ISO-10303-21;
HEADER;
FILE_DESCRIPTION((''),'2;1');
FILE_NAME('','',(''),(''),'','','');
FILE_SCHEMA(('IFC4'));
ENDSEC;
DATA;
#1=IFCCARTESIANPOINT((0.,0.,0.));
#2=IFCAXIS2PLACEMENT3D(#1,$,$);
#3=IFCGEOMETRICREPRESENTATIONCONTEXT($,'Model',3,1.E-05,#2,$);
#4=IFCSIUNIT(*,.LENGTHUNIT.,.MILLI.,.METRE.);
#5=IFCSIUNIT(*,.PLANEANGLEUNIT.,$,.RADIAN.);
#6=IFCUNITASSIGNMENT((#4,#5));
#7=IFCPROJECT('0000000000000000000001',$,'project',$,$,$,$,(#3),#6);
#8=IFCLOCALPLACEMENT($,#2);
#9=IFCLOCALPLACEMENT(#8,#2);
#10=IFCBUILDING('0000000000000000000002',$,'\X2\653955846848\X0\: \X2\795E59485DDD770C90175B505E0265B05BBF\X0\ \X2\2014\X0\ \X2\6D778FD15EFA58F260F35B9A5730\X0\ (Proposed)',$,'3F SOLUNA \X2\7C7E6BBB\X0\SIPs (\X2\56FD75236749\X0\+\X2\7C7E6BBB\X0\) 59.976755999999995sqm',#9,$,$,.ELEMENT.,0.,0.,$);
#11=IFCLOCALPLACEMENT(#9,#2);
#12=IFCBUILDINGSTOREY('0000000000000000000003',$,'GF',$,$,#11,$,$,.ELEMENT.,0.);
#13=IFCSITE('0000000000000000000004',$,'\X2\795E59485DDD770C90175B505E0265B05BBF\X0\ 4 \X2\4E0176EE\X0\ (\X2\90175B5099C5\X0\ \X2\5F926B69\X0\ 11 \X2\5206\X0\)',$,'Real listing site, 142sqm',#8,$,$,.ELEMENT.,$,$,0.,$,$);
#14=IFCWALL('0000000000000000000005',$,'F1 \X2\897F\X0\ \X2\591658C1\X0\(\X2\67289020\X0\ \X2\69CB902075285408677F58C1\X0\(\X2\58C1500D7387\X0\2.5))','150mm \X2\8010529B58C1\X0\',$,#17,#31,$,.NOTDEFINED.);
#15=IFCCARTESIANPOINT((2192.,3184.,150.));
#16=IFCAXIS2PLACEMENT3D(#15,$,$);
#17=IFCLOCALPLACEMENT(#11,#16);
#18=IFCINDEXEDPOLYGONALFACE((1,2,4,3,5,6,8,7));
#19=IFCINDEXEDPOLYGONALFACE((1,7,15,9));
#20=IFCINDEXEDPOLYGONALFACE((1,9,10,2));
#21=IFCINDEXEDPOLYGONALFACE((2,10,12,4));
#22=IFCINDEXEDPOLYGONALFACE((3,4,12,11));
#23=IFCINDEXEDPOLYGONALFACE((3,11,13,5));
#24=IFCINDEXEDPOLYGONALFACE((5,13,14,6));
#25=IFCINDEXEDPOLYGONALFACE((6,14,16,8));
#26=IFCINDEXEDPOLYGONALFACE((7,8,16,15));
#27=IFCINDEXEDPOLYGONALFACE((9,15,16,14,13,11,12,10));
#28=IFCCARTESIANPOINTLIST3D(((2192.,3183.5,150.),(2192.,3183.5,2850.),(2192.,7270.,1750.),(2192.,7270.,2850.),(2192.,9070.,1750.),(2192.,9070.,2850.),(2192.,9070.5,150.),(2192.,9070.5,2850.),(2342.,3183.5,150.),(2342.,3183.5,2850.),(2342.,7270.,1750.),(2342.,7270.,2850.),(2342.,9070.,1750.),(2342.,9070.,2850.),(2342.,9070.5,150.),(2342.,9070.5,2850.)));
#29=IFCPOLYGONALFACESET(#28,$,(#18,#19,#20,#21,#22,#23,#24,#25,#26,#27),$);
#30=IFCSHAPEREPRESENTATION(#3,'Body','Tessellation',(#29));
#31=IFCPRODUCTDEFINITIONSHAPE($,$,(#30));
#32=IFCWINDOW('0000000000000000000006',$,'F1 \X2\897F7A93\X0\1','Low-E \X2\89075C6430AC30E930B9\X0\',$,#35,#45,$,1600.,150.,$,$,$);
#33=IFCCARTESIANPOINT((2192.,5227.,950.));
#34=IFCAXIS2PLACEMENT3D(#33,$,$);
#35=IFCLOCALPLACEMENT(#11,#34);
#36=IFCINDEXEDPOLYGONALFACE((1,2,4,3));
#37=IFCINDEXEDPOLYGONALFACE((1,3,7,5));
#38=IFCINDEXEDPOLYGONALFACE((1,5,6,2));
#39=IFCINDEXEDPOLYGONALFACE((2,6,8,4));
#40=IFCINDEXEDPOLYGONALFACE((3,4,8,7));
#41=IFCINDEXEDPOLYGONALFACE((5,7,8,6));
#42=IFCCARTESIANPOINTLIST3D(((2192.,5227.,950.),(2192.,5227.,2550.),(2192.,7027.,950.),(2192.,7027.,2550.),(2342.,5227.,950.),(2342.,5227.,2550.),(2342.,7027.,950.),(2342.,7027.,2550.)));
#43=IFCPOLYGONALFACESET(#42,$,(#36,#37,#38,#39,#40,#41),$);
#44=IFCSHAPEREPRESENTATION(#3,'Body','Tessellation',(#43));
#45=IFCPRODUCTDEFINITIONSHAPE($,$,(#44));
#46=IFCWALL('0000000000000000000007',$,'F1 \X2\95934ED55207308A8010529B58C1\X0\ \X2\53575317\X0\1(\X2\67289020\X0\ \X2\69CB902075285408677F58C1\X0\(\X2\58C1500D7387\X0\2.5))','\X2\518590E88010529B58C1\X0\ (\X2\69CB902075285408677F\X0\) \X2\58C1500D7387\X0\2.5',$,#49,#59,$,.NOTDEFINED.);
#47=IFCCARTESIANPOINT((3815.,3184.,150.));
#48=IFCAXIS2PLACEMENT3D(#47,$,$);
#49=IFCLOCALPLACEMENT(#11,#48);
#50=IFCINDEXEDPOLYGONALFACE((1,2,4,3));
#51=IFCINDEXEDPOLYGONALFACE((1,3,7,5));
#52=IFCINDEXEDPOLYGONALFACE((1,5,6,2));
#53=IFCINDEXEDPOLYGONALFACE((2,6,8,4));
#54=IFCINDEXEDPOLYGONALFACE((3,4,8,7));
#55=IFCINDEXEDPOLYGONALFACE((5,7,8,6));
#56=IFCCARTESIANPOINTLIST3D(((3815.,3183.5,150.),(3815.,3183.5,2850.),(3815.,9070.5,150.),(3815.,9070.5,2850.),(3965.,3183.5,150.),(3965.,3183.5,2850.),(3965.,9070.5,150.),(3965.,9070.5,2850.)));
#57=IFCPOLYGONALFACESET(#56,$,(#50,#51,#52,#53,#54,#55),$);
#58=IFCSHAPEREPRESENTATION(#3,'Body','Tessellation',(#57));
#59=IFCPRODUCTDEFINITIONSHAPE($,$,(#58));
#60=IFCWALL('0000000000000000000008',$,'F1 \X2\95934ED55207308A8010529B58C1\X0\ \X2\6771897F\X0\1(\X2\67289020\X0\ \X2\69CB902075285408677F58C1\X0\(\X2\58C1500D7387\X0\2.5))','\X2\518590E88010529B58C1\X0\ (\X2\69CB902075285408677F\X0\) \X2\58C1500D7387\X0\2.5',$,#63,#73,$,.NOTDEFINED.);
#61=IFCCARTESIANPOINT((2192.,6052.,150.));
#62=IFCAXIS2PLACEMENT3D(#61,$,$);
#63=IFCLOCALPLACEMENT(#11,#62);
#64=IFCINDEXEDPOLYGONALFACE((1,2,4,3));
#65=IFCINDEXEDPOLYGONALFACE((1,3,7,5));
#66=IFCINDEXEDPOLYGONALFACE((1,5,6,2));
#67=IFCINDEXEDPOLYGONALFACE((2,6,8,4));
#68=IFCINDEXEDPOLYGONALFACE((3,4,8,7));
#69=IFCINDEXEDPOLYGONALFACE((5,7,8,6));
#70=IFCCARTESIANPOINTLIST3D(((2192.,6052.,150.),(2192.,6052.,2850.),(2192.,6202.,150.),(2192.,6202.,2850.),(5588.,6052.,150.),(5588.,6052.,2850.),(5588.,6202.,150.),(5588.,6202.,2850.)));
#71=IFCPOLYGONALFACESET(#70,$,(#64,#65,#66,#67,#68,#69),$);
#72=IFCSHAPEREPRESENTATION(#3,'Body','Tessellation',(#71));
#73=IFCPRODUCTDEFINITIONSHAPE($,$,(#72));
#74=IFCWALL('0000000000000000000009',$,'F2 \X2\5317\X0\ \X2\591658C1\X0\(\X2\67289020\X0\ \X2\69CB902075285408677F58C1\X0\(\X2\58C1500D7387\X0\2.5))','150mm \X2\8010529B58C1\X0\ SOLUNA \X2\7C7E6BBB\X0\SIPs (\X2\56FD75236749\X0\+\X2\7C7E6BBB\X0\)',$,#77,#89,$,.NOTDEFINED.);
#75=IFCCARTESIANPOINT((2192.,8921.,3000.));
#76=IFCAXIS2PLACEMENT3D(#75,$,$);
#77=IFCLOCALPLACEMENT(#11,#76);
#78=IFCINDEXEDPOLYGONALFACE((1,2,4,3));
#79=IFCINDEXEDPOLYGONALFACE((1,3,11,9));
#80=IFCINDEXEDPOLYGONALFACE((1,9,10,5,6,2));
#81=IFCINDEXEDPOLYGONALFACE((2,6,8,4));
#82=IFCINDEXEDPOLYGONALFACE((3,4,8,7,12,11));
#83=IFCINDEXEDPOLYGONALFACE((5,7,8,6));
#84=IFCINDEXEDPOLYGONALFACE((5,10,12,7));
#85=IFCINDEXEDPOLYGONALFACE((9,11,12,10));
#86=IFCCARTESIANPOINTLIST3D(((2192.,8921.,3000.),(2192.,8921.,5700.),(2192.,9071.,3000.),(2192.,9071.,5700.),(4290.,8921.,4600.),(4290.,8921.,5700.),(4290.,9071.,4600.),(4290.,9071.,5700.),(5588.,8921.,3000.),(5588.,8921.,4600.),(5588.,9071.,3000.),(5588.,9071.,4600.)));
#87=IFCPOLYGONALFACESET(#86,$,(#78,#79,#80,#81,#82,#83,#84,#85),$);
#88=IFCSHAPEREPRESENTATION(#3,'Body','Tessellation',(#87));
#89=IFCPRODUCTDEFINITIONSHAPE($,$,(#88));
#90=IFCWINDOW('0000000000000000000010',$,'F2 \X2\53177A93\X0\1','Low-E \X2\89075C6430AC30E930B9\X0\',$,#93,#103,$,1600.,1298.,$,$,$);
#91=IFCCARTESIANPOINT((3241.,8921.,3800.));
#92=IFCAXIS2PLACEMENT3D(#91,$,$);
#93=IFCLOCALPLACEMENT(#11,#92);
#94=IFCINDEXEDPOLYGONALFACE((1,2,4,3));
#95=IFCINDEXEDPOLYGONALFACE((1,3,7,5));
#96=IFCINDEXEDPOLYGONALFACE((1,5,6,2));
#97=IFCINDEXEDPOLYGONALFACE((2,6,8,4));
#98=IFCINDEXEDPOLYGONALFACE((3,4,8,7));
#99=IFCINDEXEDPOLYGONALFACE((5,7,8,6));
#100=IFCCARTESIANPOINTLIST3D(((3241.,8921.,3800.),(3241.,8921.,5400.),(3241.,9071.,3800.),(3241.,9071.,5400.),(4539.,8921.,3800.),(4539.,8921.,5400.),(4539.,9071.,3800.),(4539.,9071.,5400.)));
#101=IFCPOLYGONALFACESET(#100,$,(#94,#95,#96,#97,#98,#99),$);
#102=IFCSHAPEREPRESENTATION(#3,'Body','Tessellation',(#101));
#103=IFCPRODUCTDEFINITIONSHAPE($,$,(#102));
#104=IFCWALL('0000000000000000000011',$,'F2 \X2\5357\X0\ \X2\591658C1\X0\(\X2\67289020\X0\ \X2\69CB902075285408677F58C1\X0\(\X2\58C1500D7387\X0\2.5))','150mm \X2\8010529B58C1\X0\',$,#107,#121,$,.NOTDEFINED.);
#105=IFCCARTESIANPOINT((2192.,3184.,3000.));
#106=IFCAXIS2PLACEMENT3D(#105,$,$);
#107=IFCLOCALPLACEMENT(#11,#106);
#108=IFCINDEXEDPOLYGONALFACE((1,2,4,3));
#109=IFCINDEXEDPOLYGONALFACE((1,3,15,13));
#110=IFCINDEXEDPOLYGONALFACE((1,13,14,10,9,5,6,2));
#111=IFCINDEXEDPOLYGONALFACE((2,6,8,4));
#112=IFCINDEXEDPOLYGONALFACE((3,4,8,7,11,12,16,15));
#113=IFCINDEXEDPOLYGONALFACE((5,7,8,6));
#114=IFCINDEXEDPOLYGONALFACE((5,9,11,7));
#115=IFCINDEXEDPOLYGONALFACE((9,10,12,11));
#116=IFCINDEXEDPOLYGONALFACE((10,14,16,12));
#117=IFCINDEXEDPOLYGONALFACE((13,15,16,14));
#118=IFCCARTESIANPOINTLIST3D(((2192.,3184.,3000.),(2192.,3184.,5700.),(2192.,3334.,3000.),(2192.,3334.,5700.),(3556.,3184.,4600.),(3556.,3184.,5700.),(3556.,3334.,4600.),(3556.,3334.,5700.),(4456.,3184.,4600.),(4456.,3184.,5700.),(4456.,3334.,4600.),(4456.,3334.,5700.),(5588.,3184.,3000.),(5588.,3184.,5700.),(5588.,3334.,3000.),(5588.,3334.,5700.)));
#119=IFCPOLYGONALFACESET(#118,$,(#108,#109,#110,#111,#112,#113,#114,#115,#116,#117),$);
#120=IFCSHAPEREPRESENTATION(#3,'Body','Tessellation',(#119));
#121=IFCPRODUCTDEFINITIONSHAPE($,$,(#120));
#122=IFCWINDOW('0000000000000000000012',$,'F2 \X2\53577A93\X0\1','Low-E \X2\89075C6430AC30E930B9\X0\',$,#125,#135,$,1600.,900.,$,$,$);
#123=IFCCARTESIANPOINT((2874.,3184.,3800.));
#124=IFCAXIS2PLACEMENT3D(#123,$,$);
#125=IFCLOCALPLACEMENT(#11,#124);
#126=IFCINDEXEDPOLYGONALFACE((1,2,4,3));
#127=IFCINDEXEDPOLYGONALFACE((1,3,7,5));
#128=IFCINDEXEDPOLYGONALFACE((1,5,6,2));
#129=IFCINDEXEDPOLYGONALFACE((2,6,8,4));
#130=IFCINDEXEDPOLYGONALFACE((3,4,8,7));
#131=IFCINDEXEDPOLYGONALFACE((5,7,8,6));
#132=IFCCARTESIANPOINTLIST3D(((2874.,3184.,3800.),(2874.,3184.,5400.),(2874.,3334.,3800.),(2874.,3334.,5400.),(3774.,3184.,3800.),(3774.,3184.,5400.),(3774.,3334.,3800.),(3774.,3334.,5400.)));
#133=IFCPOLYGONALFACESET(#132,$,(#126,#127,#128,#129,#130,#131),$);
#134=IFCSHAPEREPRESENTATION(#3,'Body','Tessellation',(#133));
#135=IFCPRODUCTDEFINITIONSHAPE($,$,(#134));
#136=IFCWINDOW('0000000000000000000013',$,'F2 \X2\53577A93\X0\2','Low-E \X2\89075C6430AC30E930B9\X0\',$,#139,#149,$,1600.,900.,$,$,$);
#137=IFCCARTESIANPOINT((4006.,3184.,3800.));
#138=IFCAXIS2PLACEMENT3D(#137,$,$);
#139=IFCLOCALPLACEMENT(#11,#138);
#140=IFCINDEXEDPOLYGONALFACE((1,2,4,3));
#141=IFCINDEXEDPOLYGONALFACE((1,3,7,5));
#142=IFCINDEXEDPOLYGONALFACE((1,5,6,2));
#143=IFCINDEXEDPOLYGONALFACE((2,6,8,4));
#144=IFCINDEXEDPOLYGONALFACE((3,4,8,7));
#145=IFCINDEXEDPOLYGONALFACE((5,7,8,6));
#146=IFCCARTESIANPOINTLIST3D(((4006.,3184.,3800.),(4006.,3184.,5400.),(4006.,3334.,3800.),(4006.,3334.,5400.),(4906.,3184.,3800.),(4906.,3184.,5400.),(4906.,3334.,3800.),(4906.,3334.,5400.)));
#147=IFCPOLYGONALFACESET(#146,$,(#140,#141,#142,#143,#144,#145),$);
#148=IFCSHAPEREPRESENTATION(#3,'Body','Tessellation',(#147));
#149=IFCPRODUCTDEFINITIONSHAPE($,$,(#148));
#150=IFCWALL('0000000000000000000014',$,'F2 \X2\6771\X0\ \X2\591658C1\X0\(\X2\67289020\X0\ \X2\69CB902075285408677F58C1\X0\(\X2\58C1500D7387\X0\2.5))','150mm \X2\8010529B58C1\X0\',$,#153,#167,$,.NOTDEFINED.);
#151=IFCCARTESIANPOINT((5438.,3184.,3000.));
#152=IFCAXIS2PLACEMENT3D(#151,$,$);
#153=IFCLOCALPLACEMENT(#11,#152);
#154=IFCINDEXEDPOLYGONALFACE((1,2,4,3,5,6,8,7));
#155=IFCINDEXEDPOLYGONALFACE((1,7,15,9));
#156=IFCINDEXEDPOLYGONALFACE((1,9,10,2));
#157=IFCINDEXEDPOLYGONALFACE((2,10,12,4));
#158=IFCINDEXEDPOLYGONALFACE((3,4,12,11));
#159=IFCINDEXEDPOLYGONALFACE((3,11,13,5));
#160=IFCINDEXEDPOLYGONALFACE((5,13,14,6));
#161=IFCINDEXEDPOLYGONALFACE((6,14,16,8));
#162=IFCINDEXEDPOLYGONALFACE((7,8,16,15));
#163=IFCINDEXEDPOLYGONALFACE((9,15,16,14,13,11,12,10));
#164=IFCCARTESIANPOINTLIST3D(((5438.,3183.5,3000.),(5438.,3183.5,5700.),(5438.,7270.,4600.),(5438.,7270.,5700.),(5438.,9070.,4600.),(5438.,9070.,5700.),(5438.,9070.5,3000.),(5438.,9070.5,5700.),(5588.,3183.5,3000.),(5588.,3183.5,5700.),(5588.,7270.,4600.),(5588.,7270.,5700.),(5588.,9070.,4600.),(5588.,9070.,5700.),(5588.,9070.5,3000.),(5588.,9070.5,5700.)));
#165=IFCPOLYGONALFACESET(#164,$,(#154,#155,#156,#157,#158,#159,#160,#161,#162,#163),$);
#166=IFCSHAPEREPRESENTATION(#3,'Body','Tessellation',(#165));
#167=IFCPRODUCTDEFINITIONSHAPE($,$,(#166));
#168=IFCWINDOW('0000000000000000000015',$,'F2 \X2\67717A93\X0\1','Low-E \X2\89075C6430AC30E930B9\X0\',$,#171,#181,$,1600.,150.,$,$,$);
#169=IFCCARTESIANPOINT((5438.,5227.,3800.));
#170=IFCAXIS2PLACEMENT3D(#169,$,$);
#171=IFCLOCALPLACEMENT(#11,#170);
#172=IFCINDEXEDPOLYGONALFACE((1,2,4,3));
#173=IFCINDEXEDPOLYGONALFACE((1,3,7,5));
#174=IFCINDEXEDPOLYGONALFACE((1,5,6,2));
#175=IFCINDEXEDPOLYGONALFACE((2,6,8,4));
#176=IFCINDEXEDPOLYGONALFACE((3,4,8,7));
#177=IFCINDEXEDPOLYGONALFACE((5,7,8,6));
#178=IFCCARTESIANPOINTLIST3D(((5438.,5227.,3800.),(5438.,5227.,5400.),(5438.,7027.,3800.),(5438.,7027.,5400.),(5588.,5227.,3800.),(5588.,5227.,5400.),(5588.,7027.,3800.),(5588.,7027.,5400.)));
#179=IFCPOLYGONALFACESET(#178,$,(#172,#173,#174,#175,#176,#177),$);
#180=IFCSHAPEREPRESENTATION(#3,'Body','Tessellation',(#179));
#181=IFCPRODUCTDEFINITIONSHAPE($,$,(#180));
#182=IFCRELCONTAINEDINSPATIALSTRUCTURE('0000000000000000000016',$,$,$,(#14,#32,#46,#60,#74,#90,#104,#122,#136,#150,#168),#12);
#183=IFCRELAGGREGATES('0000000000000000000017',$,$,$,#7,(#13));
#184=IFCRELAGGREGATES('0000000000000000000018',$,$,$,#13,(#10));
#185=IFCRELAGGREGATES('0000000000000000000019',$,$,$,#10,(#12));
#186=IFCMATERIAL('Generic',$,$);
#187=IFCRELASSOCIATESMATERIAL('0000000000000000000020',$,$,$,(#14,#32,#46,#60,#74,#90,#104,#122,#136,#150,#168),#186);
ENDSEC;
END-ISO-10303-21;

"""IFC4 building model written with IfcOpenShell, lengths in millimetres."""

from ifc_helpers import new_model, si_unit, frame, frame_2d, origin, place, context, project, spatial, rectangle, extrude, material, element, fill, save


model = new_model("IFC4")

# Units and contexts
model_context = context("Model", 3, precision=1e-05, world=origin())
ifc_project = project(units=[si_unit("LENGTHUNIT", "METRE", prefix="MILLI"), si_unit("PLANEANGLEUNIT", "RADIAN")], contexts=[model_context])

# Site, building, storey
site_placement = place(None, origin())
site = spatial("IfcSite", under=ifc_project, at=site_placement, Name="神奈川県逗子市新宿 4 丁目 (逗子駅 徒歩 11 分)", ObjectType="Real listing site, 142sqm", CompositionType="ELEMENT", RefElevation=0.0)
building_placement = place(site_placement, origin())
building = spatial("IfcBuilding", under=site, at=building_placement, Name="改善案: 神奈川県逗子市新宿 — 海近建売想定地 (Proposed)", ObjectType="3F SOLUNA 籾殻SIPs (国産杉+籾殻) 59.976755999999995sqm", CompositionType="ELEMENT", ElevationOfRefHeight=0.0, ElevationOfTerrain=0.0)
storey_placement = place(building_placement, origin())
storey = spatial("IfcBuildingStorey", under=building, at=storey_placement, Name="GF", CompositionType="ELEMENT", Elevation=0.0)

# Shared definitions
ifc_material_1 = material(Name="Generic")

# Wall, opening, window
wall_1_placement = place(storey_placement, frame((2192.0, 3184.0, 150.0)))
wall_1 = element("IfcWall", 1, at=wall_1_placement, inside=storey, material=ifc_material_1, Name="F1 西 外壁(木造 構造用合板壁(壁倍率2.5))", Description="150mm 耐力壁", PredefinedType="NOTDEFINED", context=model_context, shape_type="SweptSolid", body=[
    extrude(rectangle(XDim=150.0, YDim=5887.0, at=frame_2d((75.0, 2943.0))), frame((2192.0, 3184.0, 150.0)), (0.0, 0.0, 1.0), 2700.0),
])
opening_1_placement = place(storey_placement, frame((2192.0, 5227.0, 950.0)))
opening_1 = element("IfcOpeningElement", 2, at=opening_1_placement, cuts=wall_1, PredefinedType="NOTDEFINED", context=model_context, shape_type="SweptSolid", body=[
    extrude(rectangle(XDim=150.0, YDim=1800.0, at=frame_2d((75.0, 900.0))), frame((2192.0, 5227.0, 950.0)), (0.0, 0.0, 1.0), 1600.0),
])
window_1_placement = place(storey_placement, frame((2192.0, 5227.0, 950.0)))
window_1 = element("IfcWindow", 3, at=window_1_placement, inside=storey, material=ifc_material_1, Name="F1 西窓1", Description="Low-E 複層ガラス", OverallHeight=1600.0, OverallWidth=150.0, context=model_context, shape_type="SweptSolid", body=[
    extrude(rectangle(XDim=150.0, YDim=1800.0, at=frame_2d((75.0, 900.0))), frame((2192.0, 5227.0, 950.0)), (0.0, 0.0, 1.0), 1600.0),
])
fill(opening_1, window_1)

# Walls
wall_2_placement = place(storey_placement, frame((3815.0, 3184.0, 150.0)))
element("IfcWall", 4, at=wall_2_placement, inside=storey, material=ifc_material_1, Name="F1 間仕切り耐力壁 南北1(木造 構造用合板壁(壁倍率2.5))", Description="内部耐力壁 (構造用合板) 壁倍率2.5", PredefinedType="NOTDEFINED", context=model_context, shape_type="SweptSolid", body=[
    extrude(rectangle(XDim=150.0, YDim=5887.0, at=frame_2d((75.0, 2943.0))), frame((3815.0, 3184.0, 150.0)), (0.0, 0.0, 1.0), 2700.0),
])
wall_3_placement = place(storey_placement, frame((2192.0, 6052.0, 150.0)))
element("IfcWall", 5, at=wall_3_placement, inside=storey, material=ifc_material_1, Name="F1 間仕切り耐力壁 東西1(木造 構造用合板壁(壁倍率2.5))", Description="内部耐力壁 (構造用合板) 壁倍率2.5", PredefinedType="NOTDEFINED", context=model_context, shape_type="SweptSolid", body=[
    extrude(rectangle(XDim=3396.0, YDim=150.0, at=frame_2d((1698.0, 75.0))), frame((2192.0, 6052.0, 150.0)), (0.0, 0.0, 1.0), 2700.0),
])

# Wall, opening, window
wall_4_placement = place(storey_placement, frame((2192.0, 8921.0, 3000.0)))
wall_4 = element("IfcWall", 6, at=wall_4_placement, inside=storey, material=ifc_material_1, Name="F2 北 外壁(木造 構造用合板壁(壁倍率2.5))", Description="150mm 耐力壁 SOLUNA 籾殻SIPs (国産杉+籾殻)", PredefinedType="NOTDEFINED", context=model_context, shape_type="SweptSolid", body=[
    extrude(rectangle(XDim=3396.0, YDim=150.0, at=frame_2d((1698.0, 75.0))), frame((2192.0, 8921.0, 3000.0)), (0.0, 0.0, 1.0), 2700.0),
])
opening_2_placement = place(storey_placement, frame((3241.0, 8921.0, 3800.0)))
opening_2 = element("IfcOpeningElement", 7, at=opening_2_placement, cuts=wall_4, PredefinedType="NOTDEFINED", context=model_context, shape_type="SweptSolid", body=[
    extrude(rectangle(XDim=1298.0, YDim=150.0, at=frame_2d((649.0, 75.0))), frame((3241.0, 8921.0, 3800.0)), (0.0, 0.0, 1.0), 1600.0),
])
window_2_placement = place(storey_placement, frame((3241.0, 8921.0, 3800.0)))
window_2 = element("IfcWindow", 8, at=window_2_placement, inside=storey, material=ifc_material_1, Name="F2 北窓1", Description="Low-E 複層ガラス", OverallHeight=1600.0, OverallWidth=1298.0, context=model_context, shape_type="SweptSolid", body=[
    extrude(rectangle(XDim=1298.0, YDim=150.0, at=frame_2d((649.0, 75.0))), frame((3241.0, 8921.0, 3800.0)), (0.0, 0.0, 1.0), 1600.0),
])
fill(opening_2, window_2)

# Wall, openings, windows
wall_5_placement = place(storey_placement, frame((2192.0, 3184.0, 3000.0)))
wall_5 = element("IfcWall", 9, at=wall_5_placement, inside=storey, material=ifc_material_1, Name="F2 南 外壁(木造 構造用合板壁(壁倍率2.5))", Description="150mm 耐力壁", PredefinedType="NOTDEFINED", context=model_context, shape_type="SweptSolid", body=[
    extrude(rectangle(XDim=3396.0, YDim=150.0, at=frame_2d((1698.0, 75.0))), frame((2192.0, 3184.0, 3000.0)), (0.0, 0.0, 1.0), 2700.0),
])
opening_3_placement = place(storey_placement, frame((2874.0, 3184.0, 3800.0)))
opening_3 = element("IfcOpeningElement", 10, at=opening_3_placement, cuts=wall_5, PredefinedType="NOTDEFINED", context=model_context, shape_type="SweptSolid", body=[
    extrude(rectangle(XDim=900.0, YDim=150.0, at=frame_2d((450.0, 75.0))), frame((2874.0, 3184.0, 3800.0)), (0.0, 0.0, 1.0), 1600.0),
])
opening_4_placement = place(storey_placement, frame((4006.0, 3184.0, 3800.0)))
opening_4 = element("IfcOpeningElement", 11, at=opening_4_placement, cuts=wall_5, PredefinedType="NOTDEFINED", context=model_context, shape_type="SweptSolid", body=[
    extrude(rectangle(XDim=900.0, YDim=150.0, at=frame_2d((450.0, 75.0))), frame((4006.0, 3184.0, 3800.0)), (0.0, 0.0, 1.0), 1600.0),
])
window_3_placement = place(storey_placement, frame((2874.0, 3184.0, 3800.0)))
window_3 = element("IfcWindow", 12, at=window_3_placement, inside=storey, material=ifc_material_1, Name="F2 南窓1", Description="Low-E 複層ガラス", OverallHeight=1600.0, OverallWidth=900.0, context=model_context, shape_type="SweptSolid", body=[
    extrude(rectangle(XDim=900.0, YDim=150.0, at=frame_2d((450.0, 75.0))), frame((2874.0, 3184.0, 3800.0)), (0.0, 0.0, 1.0), 1600.0),
])
fill(opening_3, window_3)
window_4_placement = place(storey_placement, frame((4006.0, 3184.0, 3800.0)))
window_4 = element("IfcWindow", 13, at=window_4_placement, inside=storey, material=ifc_material_1, Name="F2 南窓2", Description="Low-E 複層ガラス", OverallHeight=1600.0, OverallWidth=900.0, context=model_context, shape_type="SweptSolid", body=[
    extrude(rectangle(XDim=900.0, YDim=150.0, at=frame_2d((450.0, 75.0))), frame((4006.0, 3184.0, 3800.0)), (0.0, 0.0, 1.0), 1600.0),
])
fill(opening_4, window_4)

# Wall, opening, window
wall_6_placement = place(storey_placement, frame((5438.0, 3184.0, 3000.0)))
wall_6 = element("IfcWall", 14, at=wall_6_placement, inside=storey, material=ifc_material_1, Name="F2 東 外壁(木造 構造用合板壁(壁倍率2.5))", Description="150mm 耐力壁", PredefinedType="NOTDEFINED", context=model_context, shape_type="SweptSolid", body=[
    extrude(rectangle(XDim=150.0, YDim=5887.0, at=frame_2d((75.0, 2943.0))), frame((5438.0, 3184.0, 3000.0)), (0.0, 0.0, 1.0), 2700.0),
])
opening_5_placement = place(storey_placement, frame((5438.0, 5227.0, 3800.0)))
opening_5 = element("IfcOpeningElement", 15, at=opening_5_placement, cuts=wall_6, PredefinedType="NOTDEFINED", context=model_context, shape_type="SweptSolid", body=[
    extrude(rectangle(XDim=150.0, YDim=1800.0, at=frame_2d((75.0, 900.0))), frame((5438.0, 5227.0, 3800.0)), (0.0, 0.0, 1.0), 1600.0),
])
window_5_placement = place(storey_placement, frame((5438.0, 5227.0, 3800.0)))
window_5 = element("IfcWindow", 16, at=window_5_placement, inside=storey, material=ifc_material_1, Name="F2 東窓1", Description="Low-E 複層ガラス", OverallHeight=1600.0, OverallWidth=150.0, context=model_context, shape_type="SweptSolid", body=[
    extrude(rectangle(XDim=150.0, YDim=1800.0, at=frame_2d((75.0, 900.0))), frame((5438.0, 5227.0, 3800.0)), (0.0, 0.0, 1.0), 1600.0),
])
fill(opening_5, window_5)

save(model, "model.ifc")
